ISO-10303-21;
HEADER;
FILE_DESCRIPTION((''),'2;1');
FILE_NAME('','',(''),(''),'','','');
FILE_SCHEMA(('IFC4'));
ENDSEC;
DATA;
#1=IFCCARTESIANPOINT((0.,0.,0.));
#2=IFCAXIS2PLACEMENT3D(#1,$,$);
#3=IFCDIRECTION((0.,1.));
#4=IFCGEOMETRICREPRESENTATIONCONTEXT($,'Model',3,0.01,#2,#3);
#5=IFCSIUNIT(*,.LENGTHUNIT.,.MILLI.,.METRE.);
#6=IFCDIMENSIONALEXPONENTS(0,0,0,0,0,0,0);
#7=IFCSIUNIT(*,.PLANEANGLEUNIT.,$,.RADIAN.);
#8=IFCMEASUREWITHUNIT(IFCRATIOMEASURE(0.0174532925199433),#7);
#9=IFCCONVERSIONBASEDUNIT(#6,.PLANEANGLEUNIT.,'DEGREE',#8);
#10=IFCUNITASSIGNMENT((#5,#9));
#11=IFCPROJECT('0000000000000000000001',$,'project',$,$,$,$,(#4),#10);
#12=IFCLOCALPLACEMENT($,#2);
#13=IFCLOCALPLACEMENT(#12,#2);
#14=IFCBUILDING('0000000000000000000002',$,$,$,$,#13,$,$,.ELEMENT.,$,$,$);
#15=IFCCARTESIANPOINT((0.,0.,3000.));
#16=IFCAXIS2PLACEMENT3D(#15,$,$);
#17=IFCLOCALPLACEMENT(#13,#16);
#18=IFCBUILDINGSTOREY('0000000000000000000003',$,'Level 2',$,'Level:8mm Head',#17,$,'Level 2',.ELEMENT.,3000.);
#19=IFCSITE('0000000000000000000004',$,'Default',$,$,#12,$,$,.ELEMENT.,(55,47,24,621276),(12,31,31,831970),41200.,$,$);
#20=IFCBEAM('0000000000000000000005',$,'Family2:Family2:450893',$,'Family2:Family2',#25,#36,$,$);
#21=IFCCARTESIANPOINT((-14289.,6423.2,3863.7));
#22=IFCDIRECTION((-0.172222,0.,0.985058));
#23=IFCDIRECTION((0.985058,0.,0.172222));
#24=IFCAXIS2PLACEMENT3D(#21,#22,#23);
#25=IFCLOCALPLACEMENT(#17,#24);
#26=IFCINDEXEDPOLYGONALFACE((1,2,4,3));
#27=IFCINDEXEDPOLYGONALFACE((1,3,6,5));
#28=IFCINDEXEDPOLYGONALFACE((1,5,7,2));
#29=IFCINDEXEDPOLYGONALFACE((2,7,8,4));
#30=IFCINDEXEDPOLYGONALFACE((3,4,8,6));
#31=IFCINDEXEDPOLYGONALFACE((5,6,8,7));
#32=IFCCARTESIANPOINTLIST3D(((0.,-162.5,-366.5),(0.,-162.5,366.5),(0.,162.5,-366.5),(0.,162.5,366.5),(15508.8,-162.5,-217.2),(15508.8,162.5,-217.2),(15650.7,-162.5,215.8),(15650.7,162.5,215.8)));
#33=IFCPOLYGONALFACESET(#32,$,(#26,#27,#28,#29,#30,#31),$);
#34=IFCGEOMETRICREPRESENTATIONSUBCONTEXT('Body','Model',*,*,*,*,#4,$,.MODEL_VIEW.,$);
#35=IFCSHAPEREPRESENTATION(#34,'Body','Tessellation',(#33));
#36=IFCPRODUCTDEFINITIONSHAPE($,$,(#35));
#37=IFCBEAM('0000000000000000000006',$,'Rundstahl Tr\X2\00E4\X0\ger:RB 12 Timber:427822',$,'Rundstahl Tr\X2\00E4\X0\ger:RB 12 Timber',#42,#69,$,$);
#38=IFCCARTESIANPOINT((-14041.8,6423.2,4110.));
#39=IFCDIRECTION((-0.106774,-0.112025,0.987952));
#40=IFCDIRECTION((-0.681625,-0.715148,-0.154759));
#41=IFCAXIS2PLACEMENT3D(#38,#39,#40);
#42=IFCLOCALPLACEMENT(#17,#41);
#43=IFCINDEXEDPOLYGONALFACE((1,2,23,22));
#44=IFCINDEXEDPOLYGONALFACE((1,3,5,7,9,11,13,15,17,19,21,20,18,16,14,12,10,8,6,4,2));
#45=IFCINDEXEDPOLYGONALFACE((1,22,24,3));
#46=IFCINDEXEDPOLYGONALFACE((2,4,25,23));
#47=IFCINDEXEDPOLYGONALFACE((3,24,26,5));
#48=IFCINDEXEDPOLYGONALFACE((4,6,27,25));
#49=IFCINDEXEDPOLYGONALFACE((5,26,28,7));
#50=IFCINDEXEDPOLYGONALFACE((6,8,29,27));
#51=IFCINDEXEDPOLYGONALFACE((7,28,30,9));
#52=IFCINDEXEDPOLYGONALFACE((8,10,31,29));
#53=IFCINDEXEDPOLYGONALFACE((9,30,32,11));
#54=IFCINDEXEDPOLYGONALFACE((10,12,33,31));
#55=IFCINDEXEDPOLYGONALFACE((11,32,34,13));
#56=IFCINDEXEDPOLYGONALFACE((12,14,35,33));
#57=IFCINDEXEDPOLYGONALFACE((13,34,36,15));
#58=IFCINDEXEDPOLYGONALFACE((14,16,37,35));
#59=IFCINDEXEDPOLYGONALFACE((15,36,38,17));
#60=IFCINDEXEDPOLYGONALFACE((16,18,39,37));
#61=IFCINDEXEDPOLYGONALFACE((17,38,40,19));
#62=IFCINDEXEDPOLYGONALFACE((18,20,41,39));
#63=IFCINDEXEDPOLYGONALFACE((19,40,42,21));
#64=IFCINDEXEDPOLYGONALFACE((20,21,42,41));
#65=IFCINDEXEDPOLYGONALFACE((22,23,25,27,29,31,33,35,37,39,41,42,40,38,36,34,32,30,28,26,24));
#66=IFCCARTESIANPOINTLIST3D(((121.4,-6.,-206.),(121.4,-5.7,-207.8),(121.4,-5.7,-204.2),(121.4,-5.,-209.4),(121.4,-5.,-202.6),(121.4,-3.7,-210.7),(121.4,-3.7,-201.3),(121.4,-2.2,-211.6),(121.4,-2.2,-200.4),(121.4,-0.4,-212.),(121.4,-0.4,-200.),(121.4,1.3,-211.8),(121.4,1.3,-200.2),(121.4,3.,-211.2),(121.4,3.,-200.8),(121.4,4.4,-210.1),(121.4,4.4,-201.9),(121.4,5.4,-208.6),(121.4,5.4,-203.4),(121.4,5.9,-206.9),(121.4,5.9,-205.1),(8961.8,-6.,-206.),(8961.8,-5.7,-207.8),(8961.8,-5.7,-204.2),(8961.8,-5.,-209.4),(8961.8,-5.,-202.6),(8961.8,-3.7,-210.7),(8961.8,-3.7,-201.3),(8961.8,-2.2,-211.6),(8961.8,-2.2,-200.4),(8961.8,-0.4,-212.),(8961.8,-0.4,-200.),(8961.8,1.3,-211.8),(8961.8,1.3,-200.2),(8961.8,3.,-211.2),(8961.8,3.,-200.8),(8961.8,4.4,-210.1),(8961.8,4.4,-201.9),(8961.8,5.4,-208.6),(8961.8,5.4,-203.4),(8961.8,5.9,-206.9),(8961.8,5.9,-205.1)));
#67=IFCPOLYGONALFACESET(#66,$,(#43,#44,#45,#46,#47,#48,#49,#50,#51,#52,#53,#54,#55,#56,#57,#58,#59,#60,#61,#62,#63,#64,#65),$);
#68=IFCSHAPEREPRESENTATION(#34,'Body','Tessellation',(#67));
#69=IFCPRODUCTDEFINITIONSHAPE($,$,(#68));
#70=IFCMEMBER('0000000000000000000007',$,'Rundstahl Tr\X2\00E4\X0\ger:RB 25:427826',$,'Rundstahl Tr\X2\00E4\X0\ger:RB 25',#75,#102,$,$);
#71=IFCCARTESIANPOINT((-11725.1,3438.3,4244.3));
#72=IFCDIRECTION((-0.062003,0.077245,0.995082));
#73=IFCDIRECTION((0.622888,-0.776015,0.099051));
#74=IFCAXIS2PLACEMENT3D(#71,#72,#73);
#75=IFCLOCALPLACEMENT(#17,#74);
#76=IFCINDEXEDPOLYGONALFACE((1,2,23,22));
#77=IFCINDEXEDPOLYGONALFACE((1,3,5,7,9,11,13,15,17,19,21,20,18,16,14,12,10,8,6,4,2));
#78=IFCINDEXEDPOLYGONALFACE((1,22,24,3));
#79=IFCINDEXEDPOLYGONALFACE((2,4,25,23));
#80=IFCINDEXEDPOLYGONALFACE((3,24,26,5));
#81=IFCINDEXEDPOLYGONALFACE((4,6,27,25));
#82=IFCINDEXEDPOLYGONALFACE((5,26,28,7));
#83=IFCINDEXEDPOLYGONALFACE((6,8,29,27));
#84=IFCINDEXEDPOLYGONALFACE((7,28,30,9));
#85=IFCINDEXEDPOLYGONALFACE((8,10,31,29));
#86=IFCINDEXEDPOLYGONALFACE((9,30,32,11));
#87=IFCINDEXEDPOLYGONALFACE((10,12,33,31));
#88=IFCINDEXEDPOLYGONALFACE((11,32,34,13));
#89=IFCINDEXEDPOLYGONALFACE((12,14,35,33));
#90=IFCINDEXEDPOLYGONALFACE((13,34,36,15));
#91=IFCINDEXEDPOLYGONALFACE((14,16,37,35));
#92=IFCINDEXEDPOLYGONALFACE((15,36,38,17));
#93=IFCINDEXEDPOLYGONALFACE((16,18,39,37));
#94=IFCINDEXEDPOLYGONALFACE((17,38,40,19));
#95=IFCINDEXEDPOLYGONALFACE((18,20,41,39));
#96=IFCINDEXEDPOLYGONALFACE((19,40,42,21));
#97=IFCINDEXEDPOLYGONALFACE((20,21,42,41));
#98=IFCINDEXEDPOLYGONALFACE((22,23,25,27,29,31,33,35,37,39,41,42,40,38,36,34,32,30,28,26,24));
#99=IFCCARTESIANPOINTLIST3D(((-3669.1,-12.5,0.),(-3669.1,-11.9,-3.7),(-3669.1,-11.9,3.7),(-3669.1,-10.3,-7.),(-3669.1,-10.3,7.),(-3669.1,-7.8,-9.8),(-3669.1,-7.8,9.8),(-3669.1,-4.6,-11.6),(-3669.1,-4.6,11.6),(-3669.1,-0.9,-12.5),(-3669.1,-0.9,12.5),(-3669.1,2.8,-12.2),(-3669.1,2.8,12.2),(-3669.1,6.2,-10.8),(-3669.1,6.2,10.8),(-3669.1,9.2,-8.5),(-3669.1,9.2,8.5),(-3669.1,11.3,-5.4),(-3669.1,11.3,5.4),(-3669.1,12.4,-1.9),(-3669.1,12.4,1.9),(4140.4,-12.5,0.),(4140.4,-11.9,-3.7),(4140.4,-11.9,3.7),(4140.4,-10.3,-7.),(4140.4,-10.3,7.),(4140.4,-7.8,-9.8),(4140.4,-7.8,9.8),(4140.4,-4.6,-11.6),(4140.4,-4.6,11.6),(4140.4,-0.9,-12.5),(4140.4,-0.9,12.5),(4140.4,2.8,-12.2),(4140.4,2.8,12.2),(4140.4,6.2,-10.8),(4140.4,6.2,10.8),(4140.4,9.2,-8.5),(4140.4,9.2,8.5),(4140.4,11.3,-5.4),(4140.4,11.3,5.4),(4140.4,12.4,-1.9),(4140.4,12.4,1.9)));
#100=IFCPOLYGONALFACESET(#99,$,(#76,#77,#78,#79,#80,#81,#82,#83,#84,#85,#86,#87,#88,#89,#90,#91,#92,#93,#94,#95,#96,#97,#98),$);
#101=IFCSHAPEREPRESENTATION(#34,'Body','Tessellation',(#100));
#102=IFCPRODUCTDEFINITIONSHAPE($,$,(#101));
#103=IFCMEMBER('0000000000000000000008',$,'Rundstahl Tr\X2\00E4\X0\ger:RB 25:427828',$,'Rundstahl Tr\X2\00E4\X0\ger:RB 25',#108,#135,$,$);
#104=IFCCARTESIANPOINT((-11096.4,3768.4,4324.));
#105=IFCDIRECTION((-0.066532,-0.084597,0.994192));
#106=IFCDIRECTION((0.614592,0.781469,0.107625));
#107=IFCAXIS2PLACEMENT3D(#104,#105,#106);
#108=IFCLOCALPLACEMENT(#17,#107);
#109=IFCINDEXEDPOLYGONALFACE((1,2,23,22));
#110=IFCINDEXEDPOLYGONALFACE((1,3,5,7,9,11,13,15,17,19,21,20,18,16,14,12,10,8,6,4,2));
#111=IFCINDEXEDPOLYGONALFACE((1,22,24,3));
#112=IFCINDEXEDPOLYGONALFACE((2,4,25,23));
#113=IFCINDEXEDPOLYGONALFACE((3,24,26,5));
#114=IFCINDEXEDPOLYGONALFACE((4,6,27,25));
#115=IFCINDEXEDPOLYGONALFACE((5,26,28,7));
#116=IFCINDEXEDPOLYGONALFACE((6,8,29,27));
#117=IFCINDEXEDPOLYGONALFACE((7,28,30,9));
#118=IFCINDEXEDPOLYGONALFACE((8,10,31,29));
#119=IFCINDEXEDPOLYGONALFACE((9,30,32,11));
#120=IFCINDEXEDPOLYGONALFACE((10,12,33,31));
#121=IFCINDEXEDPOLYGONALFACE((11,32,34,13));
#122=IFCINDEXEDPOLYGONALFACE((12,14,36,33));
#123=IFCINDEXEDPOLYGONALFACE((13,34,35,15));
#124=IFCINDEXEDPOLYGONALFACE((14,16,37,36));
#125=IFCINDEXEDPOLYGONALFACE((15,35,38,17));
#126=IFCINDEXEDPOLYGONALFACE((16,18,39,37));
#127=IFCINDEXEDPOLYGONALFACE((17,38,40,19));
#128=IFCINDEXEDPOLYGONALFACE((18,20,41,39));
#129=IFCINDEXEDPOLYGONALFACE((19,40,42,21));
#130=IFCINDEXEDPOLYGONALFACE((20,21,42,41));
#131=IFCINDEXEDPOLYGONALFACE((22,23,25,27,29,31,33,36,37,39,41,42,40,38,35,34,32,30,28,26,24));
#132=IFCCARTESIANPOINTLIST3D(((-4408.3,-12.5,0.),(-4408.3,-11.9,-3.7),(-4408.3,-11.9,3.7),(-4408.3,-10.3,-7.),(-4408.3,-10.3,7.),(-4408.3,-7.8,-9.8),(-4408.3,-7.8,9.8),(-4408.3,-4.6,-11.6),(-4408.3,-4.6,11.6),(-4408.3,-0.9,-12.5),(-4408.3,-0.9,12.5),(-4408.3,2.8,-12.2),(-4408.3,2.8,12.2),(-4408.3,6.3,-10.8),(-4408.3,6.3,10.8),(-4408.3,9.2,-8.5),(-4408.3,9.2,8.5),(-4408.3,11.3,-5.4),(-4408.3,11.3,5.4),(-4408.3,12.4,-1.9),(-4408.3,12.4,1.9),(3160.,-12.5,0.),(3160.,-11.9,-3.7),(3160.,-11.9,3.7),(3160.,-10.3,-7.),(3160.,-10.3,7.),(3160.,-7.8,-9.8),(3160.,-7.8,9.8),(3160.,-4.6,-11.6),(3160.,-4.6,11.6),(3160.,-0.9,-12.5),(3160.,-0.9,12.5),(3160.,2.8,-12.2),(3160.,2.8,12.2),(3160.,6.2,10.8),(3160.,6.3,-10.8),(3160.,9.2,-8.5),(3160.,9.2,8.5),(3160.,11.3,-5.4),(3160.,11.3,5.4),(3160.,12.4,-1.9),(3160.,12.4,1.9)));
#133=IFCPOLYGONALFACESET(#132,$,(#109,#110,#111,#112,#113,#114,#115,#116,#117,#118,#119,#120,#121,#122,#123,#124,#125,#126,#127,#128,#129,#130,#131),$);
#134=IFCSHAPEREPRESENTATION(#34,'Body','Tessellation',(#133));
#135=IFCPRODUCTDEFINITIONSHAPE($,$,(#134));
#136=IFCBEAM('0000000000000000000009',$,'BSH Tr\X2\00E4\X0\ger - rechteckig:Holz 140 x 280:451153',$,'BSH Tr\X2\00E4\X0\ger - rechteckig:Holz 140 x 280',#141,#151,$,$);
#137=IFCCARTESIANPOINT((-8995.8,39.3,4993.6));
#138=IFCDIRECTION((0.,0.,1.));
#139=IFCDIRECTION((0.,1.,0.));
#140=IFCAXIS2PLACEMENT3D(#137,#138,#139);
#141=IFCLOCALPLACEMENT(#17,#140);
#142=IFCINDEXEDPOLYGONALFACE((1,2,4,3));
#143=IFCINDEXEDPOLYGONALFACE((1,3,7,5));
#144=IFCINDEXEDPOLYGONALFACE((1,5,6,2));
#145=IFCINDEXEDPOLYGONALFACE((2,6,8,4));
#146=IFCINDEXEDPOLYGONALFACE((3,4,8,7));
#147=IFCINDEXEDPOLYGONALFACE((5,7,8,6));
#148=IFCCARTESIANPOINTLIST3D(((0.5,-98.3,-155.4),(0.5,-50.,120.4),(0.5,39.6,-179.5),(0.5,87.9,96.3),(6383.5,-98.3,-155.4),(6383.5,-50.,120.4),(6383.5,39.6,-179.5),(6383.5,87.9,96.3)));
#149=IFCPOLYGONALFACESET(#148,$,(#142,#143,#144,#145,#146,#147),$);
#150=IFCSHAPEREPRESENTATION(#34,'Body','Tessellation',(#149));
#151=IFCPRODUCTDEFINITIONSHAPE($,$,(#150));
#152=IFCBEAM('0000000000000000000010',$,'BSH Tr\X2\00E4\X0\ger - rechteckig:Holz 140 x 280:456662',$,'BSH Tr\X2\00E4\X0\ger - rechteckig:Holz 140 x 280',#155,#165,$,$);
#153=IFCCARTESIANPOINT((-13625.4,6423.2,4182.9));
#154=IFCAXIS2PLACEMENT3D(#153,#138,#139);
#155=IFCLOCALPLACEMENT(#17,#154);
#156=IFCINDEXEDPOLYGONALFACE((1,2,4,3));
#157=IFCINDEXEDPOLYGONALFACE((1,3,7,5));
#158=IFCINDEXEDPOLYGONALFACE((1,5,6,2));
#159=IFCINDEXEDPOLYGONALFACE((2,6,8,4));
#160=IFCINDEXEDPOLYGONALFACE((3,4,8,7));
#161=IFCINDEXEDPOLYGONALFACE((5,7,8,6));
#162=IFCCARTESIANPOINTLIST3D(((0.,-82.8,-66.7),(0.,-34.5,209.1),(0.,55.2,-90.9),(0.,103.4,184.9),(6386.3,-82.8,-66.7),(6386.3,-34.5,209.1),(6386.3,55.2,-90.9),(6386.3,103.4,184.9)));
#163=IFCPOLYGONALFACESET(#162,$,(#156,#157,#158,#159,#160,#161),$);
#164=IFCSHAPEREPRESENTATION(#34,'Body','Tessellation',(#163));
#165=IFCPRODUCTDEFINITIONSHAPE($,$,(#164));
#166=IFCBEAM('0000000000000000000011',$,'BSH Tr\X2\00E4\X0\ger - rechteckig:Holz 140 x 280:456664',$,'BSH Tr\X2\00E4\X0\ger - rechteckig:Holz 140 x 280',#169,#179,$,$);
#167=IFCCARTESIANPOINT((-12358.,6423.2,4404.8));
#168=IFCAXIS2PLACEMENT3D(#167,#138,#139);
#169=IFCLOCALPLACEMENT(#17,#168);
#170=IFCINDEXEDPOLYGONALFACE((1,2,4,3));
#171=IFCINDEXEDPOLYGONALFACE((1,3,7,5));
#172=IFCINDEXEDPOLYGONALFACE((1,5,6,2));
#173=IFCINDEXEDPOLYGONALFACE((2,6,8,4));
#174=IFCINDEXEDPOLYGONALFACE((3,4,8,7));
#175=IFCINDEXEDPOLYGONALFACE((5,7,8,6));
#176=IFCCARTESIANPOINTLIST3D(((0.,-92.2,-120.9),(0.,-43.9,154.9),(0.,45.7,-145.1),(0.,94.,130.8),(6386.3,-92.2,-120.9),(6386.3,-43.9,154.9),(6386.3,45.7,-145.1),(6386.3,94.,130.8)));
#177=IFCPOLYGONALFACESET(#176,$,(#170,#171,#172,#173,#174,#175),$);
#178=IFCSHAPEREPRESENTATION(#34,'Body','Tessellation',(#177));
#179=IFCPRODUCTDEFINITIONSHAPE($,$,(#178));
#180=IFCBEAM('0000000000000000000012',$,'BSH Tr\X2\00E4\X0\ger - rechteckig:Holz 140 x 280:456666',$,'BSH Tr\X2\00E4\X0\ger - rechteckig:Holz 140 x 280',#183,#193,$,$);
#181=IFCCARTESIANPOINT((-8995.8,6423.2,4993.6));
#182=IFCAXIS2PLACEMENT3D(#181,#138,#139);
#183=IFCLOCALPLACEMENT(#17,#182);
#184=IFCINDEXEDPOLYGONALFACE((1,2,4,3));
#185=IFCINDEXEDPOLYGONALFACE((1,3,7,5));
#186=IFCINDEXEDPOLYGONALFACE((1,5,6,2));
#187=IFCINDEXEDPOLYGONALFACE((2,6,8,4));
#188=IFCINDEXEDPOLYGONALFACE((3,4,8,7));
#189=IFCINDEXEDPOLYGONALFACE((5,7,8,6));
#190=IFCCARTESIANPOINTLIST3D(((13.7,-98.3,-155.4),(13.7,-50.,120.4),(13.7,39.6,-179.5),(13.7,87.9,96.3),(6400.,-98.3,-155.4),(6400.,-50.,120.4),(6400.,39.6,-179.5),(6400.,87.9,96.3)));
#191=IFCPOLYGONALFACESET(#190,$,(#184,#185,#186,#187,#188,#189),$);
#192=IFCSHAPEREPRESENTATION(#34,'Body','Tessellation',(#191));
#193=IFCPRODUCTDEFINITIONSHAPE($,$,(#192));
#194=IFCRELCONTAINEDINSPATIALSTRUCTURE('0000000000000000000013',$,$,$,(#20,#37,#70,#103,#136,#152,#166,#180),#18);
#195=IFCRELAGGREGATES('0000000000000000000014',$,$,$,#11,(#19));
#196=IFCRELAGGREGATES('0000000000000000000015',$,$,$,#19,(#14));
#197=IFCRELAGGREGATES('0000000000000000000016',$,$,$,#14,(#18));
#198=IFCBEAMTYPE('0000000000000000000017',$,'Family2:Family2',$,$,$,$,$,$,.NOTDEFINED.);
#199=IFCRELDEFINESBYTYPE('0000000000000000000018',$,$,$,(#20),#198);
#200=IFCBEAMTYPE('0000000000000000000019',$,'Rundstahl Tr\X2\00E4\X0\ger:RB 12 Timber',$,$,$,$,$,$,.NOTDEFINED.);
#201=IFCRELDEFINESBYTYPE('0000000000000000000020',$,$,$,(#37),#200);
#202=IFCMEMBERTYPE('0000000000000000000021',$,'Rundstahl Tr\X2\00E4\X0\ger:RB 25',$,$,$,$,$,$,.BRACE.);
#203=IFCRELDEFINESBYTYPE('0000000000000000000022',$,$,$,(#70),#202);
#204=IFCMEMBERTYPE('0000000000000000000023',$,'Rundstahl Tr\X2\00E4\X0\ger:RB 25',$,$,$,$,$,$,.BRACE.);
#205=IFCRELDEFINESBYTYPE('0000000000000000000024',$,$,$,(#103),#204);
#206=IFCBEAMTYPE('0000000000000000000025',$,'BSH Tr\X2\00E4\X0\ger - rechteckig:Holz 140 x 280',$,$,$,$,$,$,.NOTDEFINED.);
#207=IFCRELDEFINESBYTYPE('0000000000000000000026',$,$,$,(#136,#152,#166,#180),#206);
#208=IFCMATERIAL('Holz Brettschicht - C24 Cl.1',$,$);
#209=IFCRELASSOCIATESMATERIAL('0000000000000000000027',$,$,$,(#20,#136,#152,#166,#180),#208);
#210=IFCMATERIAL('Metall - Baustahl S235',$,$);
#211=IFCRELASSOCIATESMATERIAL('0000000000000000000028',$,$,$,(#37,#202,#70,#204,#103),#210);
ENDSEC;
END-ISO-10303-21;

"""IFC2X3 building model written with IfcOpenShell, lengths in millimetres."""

from ifc_helpers import new_model, entity, si_unit, converted_unit, direction, frame, frame_2d, origin, origin_2d_with_axis, place, context, subcontext, project, spatial, polyline, rectangle, circle, extrude, clip, bounded_halfspace, source, transform, mapped, material, type_object, type_shapes, element, save


model = new_model("IFC2X3")

# Units and contexts
model_context = context("Model", 3, precision=0.01, world=origin(), true_north=direction((0.0, 1.0)))
body_context = subcontext(model_context, "Body", "Model", "MODEL_VIEW")
ifc_project = project(units=[si_unit("LENGTHUNIT", "METRE", prefix="MILLI"), converted_unit("PLANEANGLEUNIT", "DEGREE", entity("IfcRatioMeasure", 0.0174532925199433), si_unit("PLANEANGLEUNIT", "RADIAN"), dimensions=[0, 0, 0, 0, 0, 0, 0])], contexts=[model_context])

# Site, building, storey
site_placement = place(None, origin())
site = spatial("IfcSite", under=ifc_project, at=site_placement, Name="Default", CompositionType="ELEMENT", RefLatitude=(55, 47, 24, 621276), RefLongitude=(12, 31, 31, 831970), RefElevation=41200.0)
building_placement = place(site_placement, origin())
building = spatial("IfcBuilding", under=site, at=building_placement, CompositionType="ELEMENT")
storey_placement = place(building_placement, frame((0.0, 0.0, 3000.0)))
storey = spatial("IfcBuildingStorey", under=building, at=storey_placement, Name="Level 2", ObjectType="Level:8mm Head", LongName="Level 2", CompositionType="ELEMENT", Elevation=3000.0)

# Beams
ifc_material_1 = material(Name="Holz Brettschicht - C24 Cl.1")
beam_type_1 = type_object("IfcBeamType", Name="Family2:Family2", PredefinedType="NOTDEFINED")
beam_1_placement = place(storey_placement, frame((-14289.0, 6423.2, 3863.7), z_axis=(-0.172222, 0.0, 0.985058), x_axis=(0.985058, 0.0, 0.172222)))
element("IfcBeam", 1, at=beam_1_placement, inside=storey, type_object=beam_type_1, material=ifc_material_1, Name="Family2:Family2:450893", ObjectType="Family2:Family2", context=body_context, shape_type="Clipping", body=[
    clip(clip(clip(extrude(rectangle(XDim=733.0, YDim=325.0, at=frame_2d((0.0, 0.0), x_axis=(0.0, 1.0))), frame((0.0, 0.0, 0.0), z_axis=(1.0, 0.0, 0.0), x_axis=(0.0, 1.0, 0.0)), (0.0, 0.0, 1.0), 15650.7), bounded_halfspace(frame((0.0, 0.0, -366.5), z_axis=(0.009627, 0.0, -0.999954), x_axis=(0.0, 1.0, 0.0)), False, frame((0.0, 0.0, 0.0), z_axis=(1.0, 0.0, 0.0), x_axis=(0.0, 1.0, 0.0)), polyline([(-162.5, -366.5), (162.5, -366.5), (162.5, -217.2), (-162.5, -217.2), (-162.5, -366.5)]))), bounded_halfspace(frame((15700.1, 0.0, 366.5), z_axis=(0.95028, 0.0, -0.311395), x_axis=(0.311395, 0.0, 0.95028)), False, frame((0.0, 0.0, 0.0), z_axis=(1.0, 0.0, 0.0), x_axis=(0.0, 1.0, 0.0)), polyline([(-162.5, 215.8), (-162.5, -217.2), (162.5, -217.2), (162.5, 215.8), (-162.5, 215.8)]))), bounded_halfspace(frame((0.0, 0.0, 366.5), z_axis=(0.009627, 0.0, 0.999954), x_axis=(0.0, -1.0, 0.0)), False, frame((0.0, 0.0, 0.0), z_axis=(1.0, 0.0, 0.0), x_axis=(0.0, 1.0, 0.0)), polyline([(162.5, 366.5), (-162.5, 366.5), (-162.5, 215.8), (162.5, 215.8), (162.5, 366.5)]))),
])
ifc_material_2 = material(Name="Metall - Baustahl S235")
beam_type_2 = type_object("IfcBeamType", Name="Rundstahl Träger:RB 12 Timber", PredefinedType="NOTDEFINED")
beam_2_placement = place(storey_placement, frame((-14041.8, 6423.2, 4110.0), z_axis=(-0.106774, -0.112025, 0.987952), x_axis=(-0.681625, -0.715148, -0.154759)))
element("IfcBeam", 2, at=beam_2_placement, inside=storey, type_object=beam_type_2, material=ifc_material_2, Name="Rundstahl Träger:RB 12 Timber:427822", ObjectType="Rundstahl Träger:RB 12 Timber", context=body_context, shape_type="SweptSolid", body=[
    extrude(circle(Radius=6.0, at=frame_2d((0.0, 0.0), x_axis=(1.0, 0.0))), frame((121.4, 0.0, -206.0), z_axis=(1.0, 0.0, 0.0), x_axis=(0.0, -1.0, 0.0)), (0.0, 0.0, 1.0), 8840.4),
])

# Members
member_type_1 = type_object("IfcMemberType", Name="Rundstahl Träger:RB 25", PredefinedType="BRACE", material=ifc_material_2)
shared_shape_1 = source(origin(), body_context, "Body", "SweptSolid", [
    extrude(circle(Radius=12.5, at=frame_2d((0.0, 0.0), x_axis=(1.0, 0.0))), frame((-3669.1, 0.0, 0.0), z_axis=(1.0, 0.0, 0.0), x_axis=(0.0, -1.0, 0.0)), (0.0, 0.0, 1.0), 7809.4),
])
type_shapes(member_type_1, [shared_shape_1])
member_1_placement = place(storey_placement, frame((-11725.1, 3438.3, 4244.3), z_axis=(-0.062003, 0.077245, 0.995082), x_axis=(0.622888, -0.776015, 0.099051)))
element("IfcMember", 3, at=member_1_placement, inside=storey, type_object=member_type_1, material=ifc_material_2, Name="Rundstahl Träger:RB 25:427826", ObjectType="Rundstahl Träger:RB 25", context=body_context, shape_type="MappedRepresentation", body=[
    mapped(shared_shape_1, transform((0.0, 0.0, 0.0), scale=1.0)),
])
member_type_2 = type_object("IfcMemberType", Name="Rundstahl Träger:RB 25", PredefinedType="BRACE", material=ifc_material_2)
shared_shape_2 = source(origin(), body_context, "Body", "SweptSolid", [
    extrude(circle(Radius=12.5, at=frame_2d((0.0, 0.0), x_axis=(1.0, 0.0))), frame((-4408.3, 0.0, 0.0), z_axis=(1.0, 0.0, 0.0), x_axis=(0.0, -1.0, 0.0)), (0.0, 0.0, 1.0), 7568.4),
])
type_shapes(member_type_2, [shared_shape_2])
member_2_placement = place(storey_placement, frame((-11096.4, 3768.4, 4324.0), z_axis=(-0.066532, -0.084597, 0.994192), x_axis=(0.614592, 0.781469, 0.107625)))
element("IfcMember", 4, at=member_2_placement, inside=storey, type_object=member_type_2, material=ifc_material_2, Name="Rundstahl Träger:RB 25:427828", ObjectType="Rundstahl Träger:RB 25", context=body_context, shape_type="MappedRepresentation", body=[
    mapped(shared_shape_2, transform((0.0, 0.0, 0.0), scale=1.0)),
])

# Beams
beam_type_3 = type_object("IfcBeamType", Name="BSH Träger - rechteckig:Holz 140 x 280", PredefinedType="NOTDEFINED")
beam_3_placement = place(storey_placement, frame((-8995.8, 39.3, 4993.6), z_axis=(0.0, 0.0, 1.0), x_axis=(0.0, 1.0, 0.0)))
element("IfcBeam", 5, at=beam_3_placement, inside=storey, type_object=beam_type_3, material=ifc_material_1, Name="BSH Träger - rechteckig:Holz 140 x 280:451153", ObjectType="BSH Träger - rechteckig:Holz 140 x 280", context=body_context, shape_type="SweptSolid", body=[
    extrude(rectangle(XDim=280.0, YDim=140.0, at=origin_2d_with_axis()), frame((0.5, -5.2, -29.6), z_axis=(1.0, 0.0, 0.0), x_axis=(0.0, 0.172491, 0.985011)), (0.0, 0.0, 1.0), 6383.0),
])
beam_4_placement = place(storey_placement, frame((-13625.4, 6423.2, 4182.9), z_axis=(0.0, 0.0, 1.0), x_axis=(0.0, 1.0, 0.0)))
element("IfcBeam", 6, at=beam_4_placement, inside=storey, type_object=beam_type_3, material=ifc_material_1, Name="BSH Träger - rechteckig:Holz 140 x 280:456662", ObjectType="BSH Träger - rechteckig:Holz 140 x 280", context=body_context, shape_type="SweptSolid", body=[
    extrude(rectangle(XDim=280.0, YDim=140.0, at=origin_2d_with_axis()), frame((0.0, 10.3, 59.1), z_axis=(1.0, 0.0, 0.0), x_axis=(0.0, 0.172491, 0.985011)), (0.0, 0.0, 1.0), 6386.3),
])
beam_5_placement = place(storey_placement, frame((-12358.0, 6423.2, 4404.8), z_axis=(0.0, 0.0, 1.0), x_axis=(0.0, 1.0, 0.0)))
element("IfcBeam", 7, at=beam_5_placement, inside=storey, type_object=beam_type_3, material=ifc_material_1, Name="BSH Träger - rechteckig:Holz 140 x 280:456664", ObjectType="BSH Träger - rechteckig:Holz 140 x 280", context=body_context, shape_type="SweptSolid", body=[
    extrude(rectangle(XDim=280.0, YDim=140.0, at=origin_2d_with_axis()), frame((0.0, 0.9, 4.9), z_axis=(1.0, 0.0, 0.0), x_axis=(0.0, 0.172491, 0.985011)), (0.0, 0.0, 1.0), 6386.3),
])
beam_6_placement = place(storey_placement, frame((-8995.8, 6423.2, 4993.6), z_axis=(0.0, 0.0, 1.0), x_axis=(0.0, 1.0, 0.0)))
element("IfcBeam", 8, at=beam_6_placement, inside=storey, type_object=beam_type_3, material=ifc_material_1, Name="BSH Träger - rechteckig:Holz 140 x 280:456666", ObjectType="BSH Träger - rechteckig:Holz 140 x 280", context=body_context, shape_type="SweptSolid", body=[
    extrude(rectangle(XDim=280.0, YDim=140.0, at=origin_2d_with_axis()), frame((13.7, -5.2, -29.6), z_axis=(1.0, 0.0, 0.0), x_axis=(0.0, 0.172491, 0.985011)), (0.0, 0.0, 1.0), 6386.3),
])

save(model, "model.ifc")
